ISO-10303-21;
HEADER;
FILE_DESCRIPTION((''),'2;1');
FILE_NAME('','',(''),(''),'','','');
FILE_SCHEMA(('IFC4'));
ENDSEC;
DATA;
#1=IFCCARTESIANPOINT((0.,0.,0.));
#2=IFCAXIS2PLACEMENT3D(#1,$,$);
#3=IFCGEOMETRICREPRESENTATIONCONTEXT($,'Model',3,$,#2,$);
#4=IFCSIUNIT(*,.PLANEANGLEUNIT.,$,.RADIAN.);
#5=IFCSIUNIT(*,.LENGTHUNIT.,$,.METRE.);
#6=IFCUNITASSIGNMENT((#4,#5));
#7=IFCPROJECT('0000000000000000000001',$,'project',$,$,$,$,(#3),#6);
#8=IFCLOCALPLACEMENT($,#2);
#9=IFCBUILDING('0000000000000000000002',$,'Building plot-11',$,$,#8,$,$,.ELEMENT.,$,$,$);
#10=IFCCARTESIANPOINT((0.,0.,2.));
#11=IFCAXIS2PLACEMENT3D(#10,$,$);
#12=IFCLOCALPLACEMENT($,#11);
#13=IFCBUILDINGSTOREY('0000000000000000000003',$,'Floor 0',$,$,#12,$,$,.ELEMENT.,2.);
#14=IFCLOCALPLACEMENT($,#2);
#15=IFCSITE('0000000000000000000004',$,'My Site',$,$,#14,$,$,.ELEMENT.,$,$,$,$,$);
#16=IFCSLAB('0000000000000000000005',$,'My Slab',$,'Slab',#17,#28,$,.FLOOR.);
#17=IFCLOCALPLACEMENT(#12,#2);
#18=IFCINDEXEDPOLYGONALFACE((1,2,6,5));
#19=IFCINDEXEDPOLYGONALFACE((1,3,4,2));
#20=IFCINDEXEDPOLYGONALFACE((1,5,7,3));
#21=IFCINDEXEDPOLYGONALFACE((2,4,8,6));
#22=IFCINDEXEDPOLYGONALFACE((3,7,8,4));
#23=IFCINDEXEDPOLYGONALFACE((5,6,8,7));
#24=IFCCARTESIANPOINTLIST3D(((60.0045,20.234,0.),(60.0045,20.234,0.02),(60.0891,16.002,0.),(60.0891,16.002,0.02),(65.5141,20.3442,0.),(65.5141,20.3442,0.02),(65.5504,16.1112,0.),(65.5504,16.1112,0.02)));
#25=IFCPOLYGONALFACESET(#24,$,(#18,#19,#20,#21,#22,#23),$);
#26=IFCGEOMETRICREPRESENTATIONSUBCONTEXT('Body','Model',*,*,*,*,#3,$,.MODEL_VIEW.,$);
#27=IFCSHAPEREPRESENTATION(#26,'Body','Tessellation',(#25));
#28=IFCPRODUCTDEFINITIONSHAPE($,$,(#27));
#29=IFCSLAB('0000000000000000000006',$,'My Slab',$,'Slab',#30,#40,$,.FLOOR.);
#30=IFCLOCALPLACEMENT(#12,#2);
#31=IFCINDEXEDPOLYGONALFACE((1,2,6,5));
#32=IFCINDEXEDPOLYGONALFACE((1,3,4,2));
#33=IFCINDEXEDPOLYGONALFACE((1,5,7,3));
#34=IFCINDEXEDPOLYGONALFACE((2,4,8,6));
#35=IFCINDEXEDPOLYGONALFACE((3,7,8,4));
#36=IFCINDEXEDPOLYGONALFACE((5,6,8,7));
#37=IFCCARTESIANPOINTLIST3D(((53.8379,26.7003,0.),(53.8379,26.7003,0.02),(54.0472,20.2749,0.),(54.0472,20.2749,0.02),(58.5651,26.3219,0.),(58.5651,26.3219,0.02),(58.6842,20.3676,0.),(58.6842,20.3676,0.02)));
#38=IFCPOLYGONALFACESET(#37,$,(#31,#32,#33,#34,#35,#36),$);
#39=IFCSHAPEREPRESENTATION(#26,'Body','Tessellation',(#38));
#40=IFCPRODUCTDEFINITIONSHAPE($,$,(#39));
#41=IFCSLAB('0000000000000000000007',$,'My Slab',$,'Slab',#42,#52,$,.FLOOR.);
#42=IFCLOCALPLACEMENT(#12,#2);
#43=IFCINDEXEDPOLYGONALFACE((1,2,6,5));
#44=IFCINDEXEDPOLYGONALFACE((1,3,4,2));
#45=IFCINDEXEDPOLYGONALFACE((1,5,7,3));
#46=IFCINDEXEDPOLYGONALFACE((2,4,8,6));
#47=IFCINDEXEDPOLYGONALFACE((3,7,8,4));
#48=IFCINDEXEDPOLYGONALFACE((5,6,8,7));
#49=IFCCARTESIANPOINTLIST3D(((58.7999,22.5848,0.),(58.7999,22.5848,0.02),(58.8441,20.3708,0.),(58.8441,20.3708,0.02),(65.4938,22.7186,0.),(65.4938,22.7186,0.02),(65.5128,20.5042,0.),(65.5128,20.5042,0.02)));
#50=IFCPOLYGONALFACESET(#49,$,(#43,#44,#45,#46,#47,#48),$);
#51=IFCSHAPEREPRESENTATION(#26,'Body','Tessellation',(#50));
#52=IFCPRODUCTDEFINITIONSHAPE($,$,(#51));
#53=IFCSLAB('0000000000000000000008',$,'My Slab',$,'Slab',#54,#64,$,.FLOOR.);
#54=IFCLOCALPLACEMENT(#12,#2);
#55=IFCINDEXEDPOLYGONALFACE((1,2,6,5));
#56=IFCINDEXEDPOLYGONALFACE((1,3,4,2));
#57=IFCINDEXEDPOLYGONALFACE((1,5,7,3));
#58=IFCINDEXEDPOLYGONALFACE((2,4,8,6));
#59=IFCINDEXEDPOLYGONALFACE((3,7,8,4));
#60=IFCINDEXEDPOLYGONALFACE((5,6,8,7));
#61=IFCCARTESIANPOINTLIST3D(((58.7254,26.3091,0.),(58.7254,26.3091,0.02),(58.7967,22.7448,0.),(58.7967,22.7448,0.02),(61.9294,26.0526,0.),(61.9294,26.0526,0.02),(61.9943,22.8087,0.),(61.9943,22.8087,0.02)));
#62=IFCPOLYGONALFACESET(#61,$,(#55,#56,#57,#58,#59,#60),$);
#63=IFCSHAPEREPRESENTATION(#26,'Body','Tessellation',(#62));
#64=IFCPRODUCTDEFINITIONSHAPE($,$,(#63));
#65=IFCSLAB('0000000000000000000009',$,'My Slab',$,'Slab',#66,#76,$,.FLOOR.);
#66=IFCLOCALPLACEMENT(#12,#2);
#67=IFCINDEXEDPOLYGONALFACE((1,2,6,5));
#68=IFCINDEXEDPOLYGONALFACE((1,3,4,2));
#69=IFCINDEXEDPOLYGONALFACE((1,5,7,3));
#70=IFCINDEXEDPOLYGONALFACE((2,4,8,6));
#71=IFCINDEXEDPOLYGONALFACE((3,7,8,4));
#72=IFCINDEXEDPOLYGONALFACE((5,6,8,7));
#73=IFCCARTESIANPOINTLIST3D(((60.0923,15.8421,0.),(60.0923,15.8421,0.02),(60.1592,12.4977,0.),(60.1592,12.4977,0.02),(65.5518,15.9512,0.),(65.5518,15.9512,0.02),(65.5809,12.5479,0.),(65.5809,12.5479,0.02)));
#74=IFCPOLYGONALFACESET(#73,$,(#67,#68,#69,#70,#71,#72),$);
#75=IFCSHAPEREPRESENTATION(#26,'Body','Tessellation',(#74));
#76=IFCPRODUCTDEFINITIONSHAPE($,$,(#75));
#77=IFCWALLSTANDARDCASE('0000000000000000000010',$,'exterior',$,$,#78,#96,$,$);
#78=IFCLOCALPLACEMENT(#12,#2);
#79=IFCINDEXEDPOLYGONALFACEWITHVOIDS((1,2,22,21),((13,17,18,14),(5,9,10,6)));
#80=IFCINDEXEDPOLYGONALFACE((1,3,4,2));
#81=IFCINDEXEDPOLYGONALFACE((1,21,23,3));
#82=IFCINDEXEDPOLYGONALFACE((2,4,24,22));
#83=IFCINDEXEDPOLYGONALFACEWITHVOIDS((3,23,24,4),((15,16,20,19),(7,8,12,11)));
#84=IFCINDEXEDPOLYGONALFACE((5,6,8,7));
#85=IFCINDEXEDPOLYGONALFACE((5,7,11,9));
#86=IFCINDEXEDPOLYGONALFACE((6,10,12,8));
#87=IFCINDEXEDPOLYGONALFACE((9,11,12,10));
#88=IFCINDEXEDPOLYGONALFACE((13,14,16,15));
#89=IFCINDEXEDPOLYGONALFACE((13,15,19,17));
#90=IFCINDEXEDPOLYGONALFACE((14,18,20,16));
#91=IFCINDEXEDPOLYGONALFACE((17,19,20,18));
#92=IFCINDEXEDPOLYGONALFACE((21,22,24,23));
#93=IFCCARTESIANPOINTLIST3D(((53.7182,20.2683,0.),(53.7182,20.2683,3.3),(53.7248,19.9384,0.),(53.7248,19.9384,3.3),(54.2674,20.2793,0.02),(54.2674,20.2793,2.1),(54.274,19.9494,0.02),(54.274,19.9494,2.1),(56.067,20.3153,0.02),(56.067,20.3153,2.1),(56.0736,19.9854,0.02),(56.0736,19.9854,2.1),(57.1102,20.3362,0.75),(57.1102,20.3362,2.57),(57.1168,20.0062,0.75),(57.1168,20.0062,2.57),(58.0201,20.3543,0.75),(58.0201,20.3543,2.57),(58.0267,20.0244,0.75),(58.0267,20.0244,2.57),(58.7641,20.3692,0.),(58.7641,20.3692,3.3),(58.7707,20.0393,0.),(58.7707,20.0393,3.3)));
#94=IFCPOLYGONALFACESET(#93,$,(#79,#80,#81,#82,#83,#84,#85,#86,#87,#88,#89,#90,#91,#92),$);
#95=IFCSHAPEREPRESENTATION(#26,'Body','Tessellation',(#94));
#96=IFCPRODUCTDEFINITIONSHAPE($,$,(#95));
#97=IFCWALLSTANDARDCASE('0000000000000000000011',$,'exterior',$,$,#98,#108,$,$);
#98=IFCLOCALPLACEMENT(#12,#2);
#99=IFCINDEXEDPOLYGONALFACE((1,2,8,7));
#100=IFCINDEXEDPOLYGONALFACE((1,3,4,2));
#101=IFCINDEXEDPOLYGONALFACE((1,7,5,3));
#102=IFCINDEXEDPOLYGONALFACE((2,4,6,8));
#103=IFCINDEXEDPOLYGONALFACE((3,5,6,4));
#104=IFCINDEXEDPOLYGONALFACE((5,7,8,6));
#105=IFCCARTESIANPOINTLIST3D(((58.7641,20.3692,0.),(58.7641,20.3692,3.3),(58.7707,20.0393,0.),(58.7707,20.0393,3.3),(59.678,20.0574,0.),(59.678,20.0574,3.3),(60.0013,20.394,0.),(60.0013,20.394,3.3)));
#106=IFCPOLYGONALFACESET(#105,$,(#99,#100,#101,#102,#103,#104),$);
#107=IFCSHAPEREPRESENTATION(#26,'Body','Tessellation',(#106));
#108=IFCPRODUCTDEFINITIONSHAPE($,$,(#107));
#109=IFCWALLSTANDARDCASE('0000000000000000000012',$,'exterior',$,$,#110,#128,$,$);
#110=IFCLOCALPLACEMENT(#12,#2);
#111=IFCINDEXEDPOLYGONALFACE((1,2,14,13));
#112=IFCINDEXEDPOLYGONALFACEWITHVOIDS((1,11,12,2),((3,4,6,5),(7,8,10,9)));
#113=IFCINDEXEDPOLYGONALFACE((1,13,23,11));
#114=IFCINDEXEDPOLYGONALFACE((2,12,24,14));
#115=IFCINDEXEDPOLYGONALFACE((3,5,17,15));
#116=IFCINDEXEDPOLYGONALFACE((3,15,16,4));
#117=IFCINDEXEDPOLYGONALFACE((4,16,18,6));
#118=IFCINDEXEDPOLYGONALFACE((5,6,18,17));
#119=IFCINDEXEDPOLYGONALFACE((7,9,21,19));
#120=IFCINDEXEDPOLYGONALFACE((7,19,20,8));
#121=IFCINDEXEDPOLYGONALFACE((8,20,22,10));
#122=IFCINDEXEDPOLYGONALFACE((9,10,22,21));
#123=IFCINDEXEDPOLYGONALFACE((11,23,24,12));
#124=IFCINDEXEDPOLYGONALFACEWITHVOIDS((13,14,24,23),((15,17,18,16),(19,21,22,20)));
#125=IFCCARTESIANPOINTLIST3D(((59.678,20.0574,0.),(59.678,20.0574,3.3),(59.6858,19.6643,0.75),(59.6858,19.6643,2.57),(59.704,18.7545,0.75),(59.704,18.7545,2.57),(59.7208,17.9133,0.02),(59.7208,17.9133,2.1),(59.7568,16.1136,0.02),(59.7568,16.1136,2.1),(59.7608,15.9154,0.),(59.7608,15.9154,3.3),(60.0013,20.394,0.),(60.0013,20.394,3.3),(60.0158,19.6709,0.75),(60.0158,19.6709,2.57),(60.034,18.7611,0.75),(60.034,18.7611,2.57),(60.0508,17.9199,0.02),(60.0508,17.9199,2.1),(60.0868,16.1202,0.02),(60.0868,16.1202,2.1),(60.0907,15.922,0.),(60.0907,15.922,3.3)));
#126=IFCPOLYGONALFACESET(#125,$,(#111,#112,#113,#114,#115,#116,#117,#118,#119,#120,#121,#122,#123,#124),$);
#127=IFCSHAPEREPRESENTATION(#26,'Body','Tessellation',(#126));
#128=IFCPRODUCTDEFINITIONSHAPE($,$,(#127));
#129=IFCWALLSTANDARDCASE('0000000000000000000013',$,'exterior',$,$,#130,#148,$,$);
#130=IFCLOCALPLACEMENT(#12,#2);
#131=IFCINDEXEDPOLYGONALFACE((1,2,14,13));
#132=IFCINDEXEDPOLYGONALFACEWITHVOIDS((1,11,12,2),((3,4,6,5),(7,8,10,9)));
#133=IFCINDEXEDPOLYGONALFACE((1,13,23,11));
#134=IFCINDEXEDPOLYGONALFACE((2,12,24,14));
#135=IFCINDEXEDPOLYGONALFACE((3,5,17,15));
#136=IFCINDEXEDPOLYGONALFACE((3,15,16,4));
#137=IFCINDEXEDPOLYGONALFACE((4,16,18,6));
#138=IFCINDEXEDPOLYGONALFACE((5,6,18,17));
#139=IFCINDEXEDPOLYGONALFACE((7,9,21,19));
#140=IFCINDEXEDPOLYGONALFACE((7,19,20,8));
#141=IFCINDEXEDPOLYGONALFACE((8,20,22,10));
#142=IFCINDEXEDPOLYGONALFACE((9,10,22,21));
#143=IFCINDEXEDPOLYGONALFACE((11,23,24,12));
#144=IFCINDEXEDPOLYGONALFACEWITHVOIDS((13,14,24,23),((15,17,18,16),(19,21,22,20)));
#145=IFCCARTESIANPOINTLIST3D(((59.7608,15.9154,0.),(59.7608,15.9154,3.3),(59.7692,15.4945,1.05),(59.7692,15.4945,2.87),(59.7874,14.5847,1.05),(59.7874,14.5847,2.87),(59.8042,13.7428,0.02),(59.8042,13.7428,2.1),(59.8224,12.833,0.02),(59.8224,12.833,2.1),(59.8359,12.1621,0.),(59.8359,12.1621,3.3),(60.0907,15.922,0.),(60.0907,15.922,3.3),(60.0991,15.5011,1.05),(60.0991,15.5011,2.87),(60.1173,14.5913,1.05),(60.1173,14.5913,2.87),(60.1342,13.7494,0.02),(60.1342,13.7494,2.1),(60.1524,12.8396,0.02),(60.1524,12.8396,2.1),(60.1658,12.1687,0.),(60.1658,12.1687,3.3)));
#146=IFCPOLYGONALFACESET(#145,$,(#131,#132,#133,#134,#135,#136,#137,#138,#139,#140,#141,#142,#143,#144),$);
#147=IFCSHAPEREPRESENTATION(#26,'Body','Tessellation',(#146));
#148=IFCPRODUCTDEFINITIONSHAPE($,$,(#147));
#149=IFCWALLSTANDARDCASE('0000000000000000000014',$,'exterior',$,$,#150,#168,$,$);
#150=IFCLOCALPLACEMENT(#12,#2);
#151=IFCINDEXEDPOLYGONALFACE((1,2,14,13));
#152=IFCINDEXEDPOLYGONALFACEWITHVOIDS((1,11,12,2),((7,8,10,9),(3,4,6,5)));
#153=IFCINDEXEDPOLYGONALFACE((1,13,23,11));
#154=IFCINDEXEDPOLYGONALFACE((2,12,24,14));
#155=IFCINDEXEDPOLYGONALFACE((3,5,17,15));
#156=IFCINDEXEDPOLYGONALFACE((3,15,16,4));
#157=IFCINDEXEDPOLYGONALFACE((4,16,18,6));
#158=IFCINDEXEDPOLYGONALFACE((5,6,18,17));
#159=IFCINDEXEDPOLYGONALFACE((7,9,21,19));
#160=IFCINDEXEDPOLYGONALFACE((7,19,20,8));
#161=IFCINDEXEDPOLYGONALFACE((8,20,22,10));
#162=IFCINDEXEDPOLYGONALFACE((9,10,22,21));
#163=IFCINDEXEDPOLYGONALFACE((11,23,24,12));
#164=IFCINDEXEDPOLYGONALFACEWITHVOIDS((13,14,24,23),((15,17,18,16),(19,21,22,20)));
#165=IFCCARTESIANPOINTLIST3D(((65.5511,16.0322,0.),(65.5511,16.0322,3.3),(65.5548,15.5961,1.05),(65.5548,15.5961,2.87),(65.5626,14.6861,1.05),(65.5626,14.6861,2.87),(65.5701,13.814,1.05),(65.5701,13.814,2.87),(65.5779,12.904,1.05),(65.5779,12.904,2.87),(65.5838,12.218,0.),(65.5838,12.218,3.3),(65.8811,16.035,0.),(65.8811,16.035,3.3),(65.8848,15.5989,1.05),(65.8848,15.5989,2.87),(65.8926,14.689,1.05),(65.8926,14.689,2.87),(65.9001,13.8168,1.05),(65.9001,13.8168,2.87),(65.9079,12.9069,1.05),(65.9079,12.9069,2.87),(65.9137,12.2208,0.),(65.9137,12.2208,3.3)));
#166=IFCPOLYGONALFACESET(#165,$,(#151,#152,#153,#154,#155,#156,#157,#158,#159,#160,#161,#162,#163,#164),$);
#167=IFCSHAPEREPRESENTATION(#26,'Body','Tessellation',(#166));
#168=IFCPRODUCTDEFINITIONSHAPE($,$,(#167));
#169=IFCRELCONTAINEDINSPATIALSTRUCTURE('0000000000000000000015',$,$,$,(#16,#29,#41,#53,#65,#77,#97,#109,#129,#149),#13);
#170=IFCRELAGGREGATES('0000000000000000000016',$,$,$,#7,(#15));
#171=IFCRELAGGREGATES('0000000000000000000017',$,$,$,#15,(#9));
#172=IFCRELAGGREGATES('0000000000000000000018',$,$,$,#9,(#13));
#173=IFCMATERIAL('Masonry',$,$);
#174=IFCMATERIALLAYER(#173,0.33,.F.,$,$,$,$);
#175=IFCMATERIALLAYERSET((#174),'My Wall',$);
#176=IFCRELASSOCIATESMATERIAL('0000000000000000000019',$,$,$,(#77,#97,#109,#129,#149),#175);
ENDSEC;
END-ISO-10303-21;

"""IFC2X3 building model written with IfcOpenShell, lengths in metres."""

from ifc_helpers import new_model, si_unit, frame, origin, place, context, subcontext, project, spatial, polyline, outline, extrude, material, layer, layer_set, layer_usage, element, save


model = new_model("IFC2X3")

# Units and contexts
model_context = context("Model", 3, world=origin())
body_context = subcontext(model_context, "Body", "Model", "MODEL_VIEW")
ifc_project = project(units=[si_unit("PLANEANGLEUNIT", "RADIAN"), si_unit("LENGTHUNIT", "METRE")], contexts=[model_context])

# Site, building, storey
site_placement = place(None, origin())
site = spatial("IfcSite", under=ifc_project, at=site_placement, Name="My Site", CompositionType="ELEMENT")
building_placement = place(None, origin())
building = spatial("IfcBuilding", under=site, at=building_placement, Name="Building plot-11", CompositionType="ELEMENT")
storey_placement = place(None, frame((0.0, 0.0, 2.0)))
storey = spatial("IfcBuildingStorey", under=building, at=storey_placement, Name="Floor 0", CompositionType="ELEMENT", Elevation=2.0)

# Slabs
slab_1_placement = place(storey_placement, origin())
element("IfcSlab", 1, at=slab_1_placement, inside=storey, Name="My Slab", ObjectType="Slab", PredefinedType="FLOOR", context=body_context, shape_type="SweptSolid", body=[
    extrude(outline(polyline([(60.0891, 16.002), (65.5504, 16.1112), (65.5141, 20.3442), (60.0045, 20.234), (60.0891, 16.002)])), origin(), (0.0, 0.0, 1.0), 0.02),
])
slab_2_placement = place(storey_placement, origin())
element("IfcSlab", 2, at=slab_2_placement, inside=storey, Name="My Slab", ObjectType="Slab", PredefinedType="FLOOR", context=body_context, shape_type="SweptSolid", body=[
    extrude(outline(polyline([(58.6842, 20.3676), (58.5651, 26.3219), (53.8379, 26.7003), (54.0472, 20.2749), (58.6842, 20.3676)])), origin(), (0.0, 0.0, 1.0), 0.02),
])
slab_3_placement = place(storey_placement, origin())
element("IfcSlab", 3, at=slab_3_placement, inside=storey, Name="My Slab", ObjectType="Slab", PredefinedType="FLOOR", context=body_context, shape_type="SweptSolid", body=[
    extrude(outline(polyline([(58.7999, 22.5848), (58.8441, 20.3708), (65.5128, 20.5042), (65.4938, 22.7186), (58.7999, 22.5848)])), origin(), (0.0, 0.0, 1.0), 0.02),
])
slab_4_placement = place(storey_placement, origin())
element("IfcSlab", 4, at=slab_4_placement, inside=storey, Name="My Slab", ObjectType="Slab", PredefinedType="FLOOR", context=body_context, shape_type="SweptSolid", body=[
    extrude(outline(polyline([(61.9294, 26.0526), (58.7254, 26.3091), (58.7967, 22.7448), (61.9943, 22.8087), (61.9294, 26.0526)])), origin(), (0.0, 0.0, 1.0), 0.02),
])
slab_5_placement = place(storey_placement, origin())
element("IfcSlab", 5, at=slab_5_placement, inside=storey, Name="My Slab", ObjectType="Slab", PredefinedType="FLOOR", context=body_context, shape_type="SweptSolid", body=[
    extrude(outline(polyline([(60.1592, 12.4977), (65.5809, 12.5479), (65.5518, 15.9512), (60.0923, 15.8421), (60.1592, 12.4977)])), origin(), (0.0, 0.0, 1.0), 0.02),
])

# Wall, openings
ifc_material = material(Name="Masonry")
ifc_layer = layer(ifc_material, 0.33, ventilated=False)
ifc_layer_set = layer_set([ifc_layer], Name="My Wall")
ifc_layer_usage = layer_usage(ifc_layer_set, "AXIS2", "NEGATIVE", 0.08)
wall_1_placement = place(storey_placement, origin())
wall_1 = element("IfcWallStandardCase", 6, at=wall_1_placement, inside=storey, material=ifc_layer_usage, Name="exterior", context=body_context, shape_type="SweptSolid", body=[
    extrude(outline(polyline([(53.7182, 20.2683), (53.7248, 19.9384), (58.7707, 20.0393), (58.7641, 20.3692), (53.7182, 20.2683)])), origin(), (0.0, 0.0, 1.0), 3.3),
])
opening_1_placement = place(storey_placement, frame((0.0, 0.0, 0.02)))
element("IfcOpeningElement", 7, at=opening_1_placement, cuts=wall_1, ObjectType="Opening", context=body_context, shape_type="SweptSolid", body=[
    extrude(outline(polyline([(54.274, 19.9494), (56.0736, 19.9854), (56.067, 20.3153), (54.2674, 20.2793), (54.274, 19.9494)])), origin(), (0.0, 0.0, 1.0), 2.08),
])
opening_2_placement = place(storey_placement, frame((0.0, 0.0, 0.75)))
element("IfcOpeningElement", 8, at=opening_2_placement, cuts=wall_1, ObjectType="Opening", context=body_context, shape_type="SweptSolid", body=[
    extrude(outline(polyline([(57.1168, 20.0062), (58.0267, 20.0244), (58.0201, 20.3543), (57.1102, 20.3362), (57.1168, 20.0062)])), origin(), (0.0, 0.0, 1.0), 1.82),
])

# Wall
wall_2_placement = place(storey_placement, origin())
element("IfcWallStandardCase", 9, at=wall_2_placement, inside=storey, material=ifc_layer_usage, Name="exterior", context=body_context, shape_type="SweptSolid", body=[
    extrude(outline(polyline([(58.7641, 20.3692), (58.7707, 20.0393), (59.678, 20.0574), (60.0013, 20.394), (58.7641, 20.3692)])), origin(), (0.0, 0.0, 1.0), 3.3),
])

# Walls, openings
wall_3_placement = place(storey_placement, origin())
wall_3 = element("IfcWallStandardCase", 10, at=wall_3_placement, inside=storey, material=ifc_layer_usage, Name="exterior", context=body_context, shape_type="SweptSolid", body=[
    extrude(outline(polyline([(60.0013, 20.394), (59.678, 20.0574), (59.7608, 15.9154), (60.0907, 15.922), (60.0013, 20.394)])), origin(), (0.0, 0.0, 1.0), 3.3),
])
opening_3_placement = place(storey_placement, frame((0.0, 0.0, 0.75)))
element("IfcOpeningElement", 11, at=opening_3_placement, cuts=wall_3, ObjectType="Opening", context=body_context, shape_type="SweptSolid", body=[
    extrude(outline(polyline([(59.6858, 19.6643), (59.704, 18.7545), (60.034, 18.7611), (60.0158, 19.6709), (59.6858, 19.6643)])), origin(), (0.0, 0.0, 1.0), 1.82),
])
opening_4_placement = place(storey_placement, frame((0.0, 0.0, 0.02)))
element("IfcOpeningElement", 12, at=opening_4_placement, cuts=wall_3, ObjectType="Opening", context=body_context, shape_type="SweptSolid", body=[
    extrude(outline(polyline([(59.7208, 17.9133), (59.7568, 16.1136), (60.0868, 16.1202), (60.0508, 17.9199), (59.7208, 17.9133)])), origin(), (0.0, 0.0, 1.0), 2.08),
])
wall_4_placement = place(storey_placement, origin())
wall_4 = element("IfcWallStandardCase", 13, at=wall_4_placement, inside=storey, material=ifc_layer_usage, Name="exterior", context=body_context, shape_type="SweptSolid", body=[
    extrude(outline(polyline([(60.0907, 15.922), (59.7608, 15.9154), (59.8359, 12.1621), (60.1658, 12.1687), (60.0907, 15.922)])), origin(), (0.0, 0.0, 1.0), 3.3),
])
opening_5_placement = place(storey_placement, frame((0.0, 0.0, 1.05)))
element("IfcOpeningElement", 14, at=opening_5_placement, cuts=wall_4, ObjectType="Opening", context=body_context, shape_type="SweptSolid", body=[
    extrude(outline(polyline([(59.7692, 15.4945), (59.7874, 14.5847), (60.1173, 14.5913), (60.0991, 15.5011), (59.7692, 15.4945)])), origin(), (0.0, 0.0, 1.0), 1.82),
])
opening_6_placement = place(storey_placement, frame((0.0, 0.0, 0.02)))
element("IfcOpeningElement", 15, at=opening_6_placement, cuts=wall_4, ObjectType="Opening", context=body_context, shape_type="SweptSolid", body=[
    extrude(outline(polyline([(59.8042, 13.7428), (59.8224, 12.833), (60.1524, 12.8396), (60.1342, 13.7494), (59.8042, 13.7428)])), origin(), (0.0, 0.0, 1.0), 2.08),
])
wall_5_placement = place(storey_placement, origin())
wall_5 = element("IfcWallStandardCase", 16, at=wall_5_placement, inside=storey, material=ifc_layer_usage, Name="exterior", context=body_context, shape_type="SweptSolid", body=[
    extrude(outline(polyline([(65.5838, 12.218), (65.9137, 12.2208), (65.8811, 16.035), (65.5511, 16.0322), (65.5838, 12.218)])), origin(), (0.0, 0.0, 1.0), 3.3),
])
opening_7_placement = place(storey_placement, frame((0.0, 0.0, 1.05)))
element("IfcOpeningElement", 17, at=opening_7_placement, cuts=wall_5, ObjectType="Opening", context=body_context, shape_type="SweptSolid", body=[
    extrude(outline(polyline([(65.9079, 12.9069), (65.9001, 13.8168), (65.5701, 13.814), (65.5779, 12.904), (65.9079, 12.9069)])), origin(), (0.0, 0.0, 1.0), 1.82),
])
opening_8_placement = place(storey_placement, frame((0.0, 0.0, 1.05)))
element("IfcOpeningElement", 18, at=opening_8_placement, cuts=wall_5, ObjectType="Opening", context=body_context, shape_type="SweptSolid", body=[
    extrude(outline(polyline([(65.8926, 14.689), (65.8848, 15.5989), (65.5548, 15.5961), (65.5626, 14.6861), (65.8926, 14.689)])), origin(), (0.0, 0.0, 1.0), 1.82),
])

save(model, "model.ifc")
